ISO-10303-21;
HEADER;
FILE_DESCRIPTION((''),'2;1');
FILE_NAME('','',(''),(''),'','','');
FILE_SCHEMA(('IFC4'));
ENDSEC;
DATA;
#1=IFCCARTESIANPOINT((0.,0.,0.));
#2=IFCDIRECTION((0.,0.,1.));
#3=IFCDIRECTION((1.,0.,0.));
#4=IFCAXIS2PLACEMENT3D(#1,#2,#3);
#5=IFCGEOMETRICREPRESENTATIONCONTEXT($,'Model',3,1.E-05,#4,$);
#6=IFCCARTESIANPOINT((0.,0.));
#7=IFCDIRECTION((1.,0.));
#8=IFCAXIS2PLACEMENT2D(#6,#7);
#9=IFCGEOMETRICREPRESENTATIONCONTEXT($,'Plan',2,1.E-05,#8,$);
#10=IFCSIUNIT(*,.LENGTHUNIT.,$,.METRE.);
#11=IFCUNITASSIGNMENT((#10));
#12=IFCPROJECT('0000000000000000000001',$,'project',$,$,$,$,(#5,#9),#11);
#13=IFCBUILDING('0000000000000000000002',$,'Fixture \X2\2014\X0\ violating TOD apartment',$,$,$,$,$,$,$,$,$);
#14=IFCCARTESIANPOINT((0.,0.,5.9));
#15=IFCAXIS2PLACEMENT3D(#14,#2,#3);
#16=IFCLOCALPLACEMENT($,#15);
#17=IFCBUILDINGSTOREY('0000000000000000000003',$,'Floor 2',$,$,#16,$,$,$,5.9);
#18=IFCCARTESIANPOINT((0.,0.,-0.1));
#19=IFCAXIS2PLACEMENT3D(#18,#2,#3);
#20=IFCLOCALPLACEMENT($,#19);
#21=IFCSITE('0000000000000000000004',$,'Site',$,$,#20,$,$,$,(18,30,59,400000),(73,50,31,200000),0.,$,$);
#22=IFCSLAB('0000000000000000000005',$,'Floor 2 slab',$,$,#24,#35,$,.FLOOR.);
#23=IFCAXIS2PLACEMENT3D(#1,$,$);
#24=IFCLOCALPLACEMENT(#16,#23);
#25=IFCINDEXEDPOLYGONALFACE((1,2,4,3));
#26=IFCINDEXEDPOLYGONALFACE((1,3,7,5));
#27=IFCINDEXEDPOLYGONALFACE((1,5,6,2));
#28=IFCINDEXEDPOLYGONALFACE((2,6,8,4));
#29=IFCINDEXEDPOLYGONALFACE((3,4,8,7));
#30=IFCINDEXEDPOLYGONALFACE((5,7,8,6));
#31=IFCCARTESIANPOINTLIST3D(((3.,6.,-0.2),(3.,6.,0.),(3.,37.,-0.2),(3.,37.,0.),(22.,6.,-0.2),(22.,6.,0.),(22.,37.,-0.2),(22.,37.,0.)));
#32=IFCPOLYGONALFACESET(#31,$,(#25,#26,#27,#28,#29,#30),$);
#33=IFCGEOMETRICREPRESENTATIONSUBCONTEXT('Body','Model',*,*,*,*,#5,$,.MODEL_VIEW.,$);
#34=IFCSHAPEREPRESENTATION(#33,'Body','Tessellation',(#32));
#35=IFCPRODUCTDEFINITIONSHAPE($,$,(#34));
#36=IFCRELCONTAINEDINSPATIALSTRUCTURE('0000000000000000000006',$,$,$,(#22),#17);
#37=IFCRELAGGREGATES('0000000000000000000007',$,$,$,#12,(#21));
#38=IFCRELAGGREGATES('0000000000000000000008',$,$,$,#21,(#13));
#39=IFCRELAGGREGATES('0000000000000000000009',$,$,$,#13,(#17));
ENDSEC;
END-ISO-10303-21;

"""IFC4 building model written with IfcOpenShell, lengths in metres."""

from ifc_helpers import new_model, si_unit, frame, origin_with_axes, origin_2d_with_axis, place, context, subcontext, project, spatial, line, indexed_curve, outline, extrude, element, save


model = new_model("IFC4")

# Units and contexts
model_context = context("Model", 3, precision=1e-05, world=origin_with_axes())
plan_context = context("Plan", 2, precision=1e-05, world=origin_2d_with_axis())
body_context = subcontext(model_context, "Body", "Model", "MODEL_VIEW")
ifc_project = project(units=[si_unit("LENGTHUNIT", "METRE")], contexts=[model_context, plan_context])

# Site, building, storey
site_placement = place(None, frame((0.0, 0.0, -0.1), z_axis=(0.0, 0.0, 1.0), x_axis=(1.0, 0.0, 0.0)))
site = spatial("IfcSite", under=ifc_project, at=site_placement, Name="Site", RefLatitude=(18, 30, 59, 400000), RefLongitude=(73, 50, 31, 200000), RefElevation=0.0)
building = spatial("IfcBuilding", under=site, Name="Fixture — violating TOD apartment")
storey_placement = place(None, frame((0.0, 0.0, 5.9), z_axis=(0.0, 0.0, 1.0), x_axis=(1.0, 0.0, 0.0)))
storey = spatial("IfcBuildingStorey", under=building, at=storey_placement, Name="Floor 2", Elevation=5.9)

# Slab
slab_placement = place(storey_placement, frame((0.0, 0.0, -0.2), z_axis=(0.0, 0.0, 1.0), x_axis=(1.0, 0.0, 0.0)))
element("IfcSlab", 1, at=slab_placement, inside=storey, Name="Floor 2 slab", PredefinedType="FLOOR", context=body_context, shape_type="SweptSolid", body=[
    extrude(outline(indexed_curve([(3.0, 6.0), (22.0, 6.0), (22.0, 37.0), (3.0, 37.0)], segments=[line(1, 2, 3, 4, 1)])), origin_with_axes(), (0.0, 0.0, 1.0), 0.2),
])

save(model, "model.ifc")
